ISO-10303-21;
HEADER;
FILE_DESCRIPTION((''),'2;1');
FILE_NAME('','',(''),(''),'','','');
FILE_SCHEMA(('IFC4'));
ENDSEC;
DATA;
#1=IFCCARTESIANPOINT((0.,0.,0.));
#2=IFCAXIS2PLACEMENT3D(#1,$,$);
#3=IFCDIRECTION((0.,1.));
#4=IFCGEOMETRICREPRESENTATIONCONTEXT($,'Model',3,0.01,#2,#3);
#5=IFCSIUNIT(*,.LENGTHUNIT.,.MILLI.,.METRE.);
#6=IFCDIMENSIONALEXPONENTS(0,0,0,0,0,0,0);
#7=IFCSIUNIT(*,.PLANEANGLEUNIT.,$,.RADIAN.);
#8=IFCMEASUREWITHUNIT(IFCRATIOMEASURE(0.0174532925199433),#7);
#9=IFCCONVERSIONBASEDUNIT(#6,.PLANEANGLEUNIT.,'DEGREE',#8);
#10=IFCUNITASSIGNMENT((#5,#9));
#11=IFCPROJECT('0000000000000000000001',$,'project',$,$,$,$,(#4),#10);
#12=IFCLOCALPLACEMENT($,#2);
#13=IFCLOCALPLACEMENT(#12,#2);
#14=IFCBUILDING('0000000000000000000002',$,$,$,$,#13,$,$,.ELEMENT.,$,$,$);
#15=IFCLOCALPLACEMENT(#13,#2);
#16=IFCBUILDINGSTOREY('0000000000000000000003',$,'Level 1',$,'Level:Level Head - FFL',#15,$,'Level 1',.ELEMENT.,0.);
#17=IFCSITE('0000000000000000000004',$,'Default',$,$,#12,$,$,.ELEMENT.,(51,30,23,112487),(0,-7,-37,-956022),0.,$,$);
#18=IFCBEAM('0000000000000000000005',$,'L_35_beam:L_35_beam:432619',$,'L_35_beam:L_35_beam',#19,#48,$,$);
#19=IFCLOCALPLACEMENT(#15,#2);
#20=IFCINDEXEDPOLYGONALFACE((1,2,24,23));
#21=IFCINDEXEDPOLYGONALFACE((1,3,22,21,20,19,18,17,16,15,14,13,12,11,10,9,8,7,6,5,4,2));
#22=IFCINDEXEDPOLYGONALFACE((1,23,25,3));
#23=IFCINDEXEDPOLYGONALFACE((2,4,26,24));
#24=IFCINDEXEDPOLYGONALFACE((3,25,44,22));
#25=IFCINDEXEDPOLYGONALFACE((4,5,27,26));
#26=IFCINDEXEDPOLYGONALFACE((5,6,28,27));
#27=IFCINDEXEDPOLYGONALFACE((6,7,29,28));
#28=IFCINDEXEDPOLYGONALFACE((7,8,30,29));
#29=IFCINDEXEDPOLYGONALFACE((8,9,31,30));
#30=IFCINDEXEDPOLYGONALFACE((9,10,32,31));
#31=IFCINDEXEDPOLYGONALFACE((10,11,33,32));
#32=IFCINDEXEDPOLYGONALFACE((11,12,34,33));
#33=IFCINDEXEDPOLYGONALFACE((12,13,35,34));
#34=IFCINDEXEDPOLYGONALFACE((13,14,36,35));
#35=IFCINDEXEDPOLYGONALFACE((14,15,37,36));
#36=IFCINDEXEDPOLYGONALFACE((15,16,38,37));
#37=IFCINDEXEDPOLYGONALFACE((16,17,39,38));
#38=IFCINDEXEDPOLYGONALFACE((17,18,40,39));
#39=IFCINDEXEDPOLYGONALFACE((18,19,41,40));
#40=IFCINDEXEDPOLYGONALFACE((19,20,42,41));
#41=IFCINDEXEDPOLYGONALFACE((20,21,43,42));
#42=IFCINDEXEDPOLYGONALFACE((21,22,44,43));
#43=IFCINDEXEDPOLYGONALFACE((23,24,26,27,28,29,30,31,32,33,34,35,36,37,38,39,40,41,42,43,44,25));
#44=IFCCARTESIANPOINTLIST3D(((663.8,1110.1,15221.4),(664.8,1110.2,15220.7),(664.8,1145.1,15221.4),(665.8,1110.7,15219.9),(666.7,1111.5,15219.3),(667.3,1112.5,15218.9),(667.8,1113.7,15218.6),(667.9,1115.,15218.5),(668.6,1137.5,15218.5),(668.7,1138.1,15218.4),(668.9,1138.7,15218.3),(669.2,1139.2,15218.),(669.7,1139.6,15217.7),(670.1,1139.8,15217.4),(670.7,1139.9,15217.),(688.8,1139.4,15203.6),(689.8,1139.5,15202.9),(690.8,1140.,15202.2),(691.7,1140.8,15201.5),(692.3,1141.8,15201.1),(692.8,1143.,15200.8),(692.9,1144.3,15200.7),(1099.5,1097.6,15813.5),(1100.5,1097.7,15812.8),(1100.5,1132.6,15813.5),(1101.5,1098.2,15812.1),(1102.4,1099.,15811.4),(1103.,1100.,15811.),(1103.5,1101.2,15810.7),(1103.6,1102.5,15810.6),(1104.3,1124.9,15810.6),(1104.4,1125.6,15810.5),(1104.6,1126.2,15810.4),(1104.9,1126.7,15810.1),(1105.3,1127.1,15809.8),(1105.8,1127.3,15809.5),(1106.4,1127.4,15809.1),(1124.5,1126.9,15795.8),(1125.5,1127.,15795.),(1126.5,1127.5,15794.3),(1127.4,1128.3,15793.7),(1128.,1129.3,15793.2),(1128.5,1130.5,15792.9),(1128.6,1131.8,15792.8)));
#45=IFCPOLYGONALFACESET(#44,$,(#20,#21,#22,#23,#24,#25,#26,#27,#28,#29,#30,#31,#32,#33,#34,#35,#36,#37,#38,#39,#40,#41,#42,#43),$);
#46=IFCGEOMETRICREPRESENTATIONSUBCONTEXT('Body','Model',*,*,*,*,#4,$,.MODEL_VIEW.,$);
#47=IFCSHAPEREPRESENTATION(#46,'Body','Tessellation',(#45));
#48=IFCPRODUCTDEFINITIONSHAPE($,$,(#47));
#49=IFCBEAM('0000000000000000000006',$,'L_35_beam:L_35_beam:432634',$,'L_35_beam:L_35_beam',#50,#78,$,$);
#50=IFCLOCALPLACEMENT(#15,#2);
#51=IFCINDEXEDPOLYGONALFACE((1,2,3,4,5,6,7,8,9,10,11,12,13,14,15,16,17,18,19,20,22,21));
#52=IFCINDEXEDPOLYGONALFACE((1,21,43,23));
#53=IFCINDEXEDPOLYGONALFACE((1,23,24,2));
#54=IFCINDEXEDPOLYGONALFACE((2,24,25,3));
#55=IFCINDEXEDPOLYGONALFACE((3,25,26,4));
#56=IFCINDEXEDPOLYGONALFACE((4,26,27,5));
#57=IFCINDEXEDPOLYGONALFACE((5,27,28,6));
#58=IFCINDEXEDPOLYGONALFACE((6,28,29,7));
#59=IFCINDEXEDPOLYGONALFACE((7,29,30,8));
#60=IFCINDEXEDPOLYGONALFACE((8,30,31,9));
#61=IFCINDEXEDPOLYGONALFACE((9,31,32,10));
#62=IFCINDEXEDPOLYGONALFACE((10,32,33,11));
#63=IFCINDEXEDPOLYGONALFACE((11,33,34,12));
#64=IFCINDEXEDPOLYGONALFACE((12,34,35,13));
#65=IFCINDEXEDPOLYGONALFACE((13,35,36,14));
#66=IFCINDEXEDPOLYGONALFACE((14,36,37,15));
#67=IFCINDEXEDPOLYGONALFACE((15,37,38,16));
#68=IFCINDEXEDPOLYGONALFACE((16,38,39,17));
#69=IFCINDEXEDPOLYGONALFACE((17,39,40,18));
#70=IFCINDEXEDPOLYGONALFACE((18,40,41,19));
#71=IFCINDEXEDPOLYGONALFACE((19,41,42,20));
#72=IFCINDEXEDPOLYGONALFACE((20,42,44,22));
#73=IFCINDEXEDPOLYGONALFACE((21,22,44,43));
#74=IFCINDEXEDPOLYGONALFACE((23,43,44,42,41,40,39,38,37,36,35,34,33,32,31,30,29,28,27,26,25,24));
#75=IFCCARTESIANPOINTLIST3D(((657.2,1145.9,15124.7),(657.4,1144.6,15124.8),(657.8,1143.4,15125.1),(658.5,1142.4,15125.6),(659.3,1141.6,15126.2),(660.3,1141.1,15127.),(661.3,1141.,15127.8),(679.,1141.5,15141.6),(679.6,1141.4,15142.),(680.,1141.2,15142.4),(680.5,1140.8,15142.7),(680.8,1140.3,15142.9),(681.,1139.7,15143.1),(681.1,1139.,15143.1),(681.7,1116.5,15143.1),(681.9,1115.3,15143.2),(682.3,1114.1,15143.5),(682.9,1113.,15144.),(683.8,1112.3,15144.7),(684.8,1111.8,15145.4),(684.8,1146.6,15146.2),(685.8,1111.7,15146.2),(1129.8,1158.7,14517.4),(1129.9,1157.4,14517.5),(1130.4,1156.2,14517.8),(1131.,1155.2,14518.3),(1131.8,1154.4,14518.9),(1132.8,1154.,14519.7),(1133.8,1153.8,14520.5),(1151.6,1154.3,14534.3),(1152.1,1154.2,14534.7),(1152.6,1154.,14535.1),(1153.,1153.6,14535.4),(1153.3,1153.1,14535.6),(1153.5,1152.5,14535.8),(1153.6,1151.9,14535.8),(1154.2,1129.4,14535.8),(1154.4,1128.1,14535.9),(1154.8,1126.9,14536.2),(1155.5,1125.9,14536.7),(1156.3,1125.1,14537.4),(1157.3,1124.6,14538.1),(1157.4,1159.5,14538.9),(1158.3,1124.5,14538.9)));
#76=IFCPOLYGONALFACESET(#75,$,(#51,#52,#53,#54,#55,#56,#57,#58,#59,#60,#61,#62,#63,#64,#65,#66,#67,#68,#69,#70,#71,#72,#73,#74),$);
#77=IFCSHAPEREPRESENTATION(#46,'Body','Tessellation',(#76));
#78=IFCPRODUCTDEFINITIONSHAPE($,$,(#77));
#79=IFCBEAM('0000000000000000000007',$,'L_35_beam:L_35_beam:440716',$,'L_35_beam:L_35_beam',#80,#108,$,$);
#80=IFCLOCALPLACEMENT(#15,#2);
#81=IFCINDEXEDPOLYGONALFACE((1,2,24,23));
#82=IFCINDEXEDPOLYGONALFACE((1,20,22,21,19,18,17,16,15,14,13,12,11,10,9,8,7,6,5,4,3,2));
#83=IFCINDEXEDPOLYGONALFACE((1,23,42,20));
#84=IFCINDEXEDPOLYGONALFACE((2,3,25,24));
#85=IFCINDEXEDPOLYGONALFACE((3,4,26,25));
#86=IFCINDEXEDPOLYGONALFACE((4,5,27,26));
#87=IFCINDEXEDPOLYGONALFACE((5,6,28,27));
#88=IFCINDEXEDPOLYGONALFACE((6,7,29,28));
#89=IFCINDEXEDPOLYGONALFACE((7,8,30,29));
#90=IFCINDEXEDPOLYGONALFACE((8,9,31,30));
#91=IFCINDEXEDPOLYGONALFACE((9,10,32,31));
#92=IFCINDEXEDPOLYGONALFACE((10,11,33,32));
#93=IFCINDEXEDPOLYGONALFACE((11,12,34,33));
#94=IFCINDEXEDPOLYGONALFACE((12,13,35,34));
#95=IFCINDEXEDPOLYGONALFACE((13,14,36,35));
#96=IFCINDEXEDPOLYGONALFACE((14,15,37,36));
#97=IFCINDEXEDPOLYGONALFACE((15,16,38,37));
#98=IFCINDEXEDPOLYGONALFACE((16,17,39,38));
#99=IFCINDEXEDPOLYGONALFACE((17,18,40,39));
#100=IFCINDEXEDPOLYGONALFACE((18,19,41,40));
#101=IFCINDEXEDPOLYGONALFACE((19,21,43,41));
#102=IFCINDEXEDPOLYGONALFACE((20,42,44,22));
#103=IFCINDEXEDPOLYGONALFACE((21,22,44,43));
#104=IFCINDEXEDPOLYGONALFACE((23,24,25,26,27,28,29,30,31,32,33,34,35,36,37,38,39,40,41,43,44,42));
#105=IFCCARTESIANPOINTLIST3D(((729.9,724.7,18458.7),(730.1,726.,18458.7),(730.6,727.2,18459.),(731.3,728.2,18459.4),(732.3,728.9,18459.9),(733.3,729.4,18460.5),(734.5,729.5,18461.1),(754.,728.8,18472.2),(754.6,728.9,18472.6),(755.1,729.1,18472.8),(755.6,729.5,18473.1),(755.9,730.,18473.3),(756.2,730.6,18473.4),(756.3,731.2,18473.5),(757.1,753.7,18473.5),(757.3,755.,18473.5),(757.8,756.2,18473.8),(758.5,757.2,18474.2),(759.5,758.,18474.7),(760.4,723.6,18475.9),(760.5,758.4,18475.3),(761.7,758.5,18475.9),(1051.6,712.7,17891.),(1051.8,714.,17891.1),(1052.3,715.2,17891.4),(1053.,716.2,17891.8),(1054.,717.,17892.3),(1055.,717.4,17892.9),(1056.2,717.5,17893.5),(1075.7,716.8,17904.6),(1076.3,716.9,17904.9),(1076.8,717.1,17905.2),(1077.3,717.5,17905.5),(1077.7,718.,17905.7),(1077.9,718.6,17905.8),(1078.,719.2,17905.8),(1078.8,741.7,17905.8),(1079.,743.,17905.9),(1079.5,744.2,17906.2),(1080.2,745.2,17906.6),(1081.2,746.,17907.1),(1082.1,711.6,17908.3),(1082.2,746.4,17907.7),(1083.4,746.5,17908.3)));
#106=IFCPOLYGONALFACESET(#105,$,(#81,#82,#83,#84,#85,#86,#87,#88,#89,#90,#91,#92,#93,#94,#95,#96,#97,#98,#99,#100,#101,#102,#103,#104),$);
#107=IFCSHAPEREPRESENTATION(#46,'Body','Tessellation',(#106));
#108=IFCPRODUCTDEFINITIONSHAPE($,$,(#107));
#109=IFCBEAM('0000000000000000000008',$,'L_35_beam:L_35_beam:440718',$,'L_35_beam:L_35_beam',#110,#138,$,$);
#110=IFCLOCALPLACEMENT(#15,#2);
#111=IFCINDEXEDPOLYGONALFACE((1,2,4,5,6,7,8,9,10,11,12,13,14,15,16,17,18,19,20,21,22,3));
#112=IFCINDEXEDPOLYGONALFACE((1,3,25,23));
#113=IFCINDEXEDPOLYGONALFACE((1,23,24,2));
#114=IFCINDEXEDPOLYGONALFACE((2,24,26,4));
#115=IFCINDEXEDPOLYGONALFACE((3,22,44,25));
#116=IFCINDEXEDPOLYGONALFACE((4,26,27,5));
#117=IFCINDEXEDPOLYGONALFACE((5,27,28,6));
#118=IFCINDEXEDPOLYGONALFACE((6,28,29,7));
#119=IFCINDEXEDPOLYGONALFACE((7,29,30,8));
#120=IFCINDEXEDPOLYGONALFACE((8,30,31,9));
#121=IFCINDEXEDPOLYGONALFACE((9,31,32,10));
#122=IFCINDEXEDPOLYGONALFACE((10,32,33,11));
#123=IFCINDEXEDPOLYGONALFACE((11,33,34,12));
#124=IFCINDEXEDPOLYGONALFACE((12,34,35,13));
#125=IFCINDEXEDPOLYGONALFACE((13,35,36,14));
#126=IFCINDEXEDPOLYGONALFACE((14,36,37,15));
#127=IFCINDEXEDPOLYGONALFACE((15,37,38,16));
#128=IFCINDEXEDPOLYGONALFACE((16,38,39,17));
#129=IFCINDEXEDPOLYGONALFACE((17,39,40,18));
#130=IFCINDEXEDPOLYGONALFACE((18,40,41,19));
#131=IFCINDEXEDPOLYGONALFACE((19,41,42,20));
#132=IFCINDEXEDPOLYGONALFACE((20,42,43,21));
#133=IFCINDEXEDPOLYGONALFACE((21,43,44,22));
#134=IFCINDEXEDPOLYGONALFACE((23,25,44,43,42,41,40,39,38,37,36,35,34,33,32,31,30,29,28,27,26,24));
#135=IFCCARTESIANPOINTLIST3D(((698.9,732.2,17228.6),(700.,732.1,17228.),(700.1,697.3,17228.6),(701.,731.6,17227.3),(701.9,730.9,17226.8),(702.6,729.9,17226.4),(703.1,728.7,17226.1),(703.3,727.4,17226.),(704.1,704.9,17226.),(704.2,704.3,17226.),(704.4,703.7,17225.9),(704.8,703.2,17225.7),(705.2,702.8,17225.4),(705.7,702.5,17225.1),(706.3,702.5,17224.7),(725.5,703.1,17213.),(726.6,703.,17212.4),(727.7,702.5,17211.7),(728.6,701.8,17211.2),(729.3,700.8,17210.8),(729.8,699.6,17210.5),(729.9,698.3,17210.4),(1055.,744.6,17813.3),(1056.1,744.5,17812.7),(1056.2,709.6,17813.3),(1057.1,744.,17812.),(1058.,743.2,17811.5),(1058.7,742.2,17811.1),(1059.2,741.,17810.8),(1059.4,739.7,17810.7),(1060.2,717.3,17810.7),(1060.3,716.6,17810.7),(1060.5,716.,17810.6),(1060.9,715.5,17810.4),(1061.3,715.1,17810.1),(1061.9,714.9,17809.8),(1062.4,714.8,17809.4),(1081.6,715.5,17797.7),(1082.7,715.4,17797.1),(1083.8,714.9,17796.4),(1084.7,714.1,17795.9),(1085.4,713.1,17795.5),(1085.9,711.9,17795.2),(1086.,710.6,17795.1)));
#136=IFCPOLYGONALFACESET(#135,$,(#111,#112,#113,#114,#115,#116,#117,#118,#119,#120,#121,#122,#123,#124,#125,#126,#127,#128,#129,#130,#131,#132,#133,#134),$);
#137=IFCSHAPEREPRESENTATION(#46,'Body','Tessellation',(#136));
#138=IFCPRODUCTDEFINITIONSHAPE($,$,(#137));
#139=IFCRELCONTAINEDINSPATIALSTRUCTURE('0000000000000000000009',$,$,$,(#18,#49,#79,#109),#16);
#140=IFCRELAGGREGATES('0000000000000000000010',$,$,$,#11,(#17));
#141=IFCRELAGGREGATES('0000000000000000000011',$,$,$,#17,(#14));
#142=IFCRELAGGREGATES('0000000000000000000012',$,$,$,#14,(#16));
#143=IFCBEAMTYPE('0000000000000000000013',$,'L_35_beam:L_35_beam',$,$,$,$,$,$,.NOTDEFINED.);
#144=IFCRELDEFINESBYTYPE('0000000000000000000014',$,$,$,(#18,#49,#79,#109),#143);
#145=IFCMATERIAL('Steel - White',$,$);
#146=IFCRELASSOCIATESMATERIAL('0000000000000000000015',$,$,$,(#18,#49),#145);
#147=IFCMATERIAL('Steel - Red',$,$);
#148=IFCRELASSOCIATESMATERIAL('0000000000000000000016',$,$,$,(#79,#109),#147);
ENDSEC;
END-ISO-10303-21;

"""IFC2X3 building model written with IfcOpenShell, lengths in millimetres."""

from ifc_helpers import new_model, entity, si_unit, converted_unit, direction, frame, frame_2d, origin, place, context, subcontext, project, spatial, polyline, circle_curve, parameter, trimmed, segment, composite_curve, outline, extrude, material, type_object, element, save


model = new_model("IFC2X3")

# Units and contexts
model_context = context("Model", 3, precision=0.01, world=origin(), true_north=direction((0.0, 1.0)))
body_context = subcontext(model_context, "Body", "Model", "MODEL_VIEW")
ifc_project = project(units=[si_unit("LENGTHUNIT", "METRE", prefix="MILLI"), converted_unit("PLANEANGLEUNIT", "DEGREE", entity("IfcRatioMeasure", 0.0174532925199433), si_unit("PLANEANGLEUNIT", "RADIAN"), dimensions=[0, 0, 0, 0, 0, 0, 0])], contexts=[model_context])

# Site, building, storey
site_placement = place(None, origin())
site = spatial("IfcSite", under=ifc_project, at=site_placement, Name="Default", CompositionType="ELEMENT", RefLatitude=(51, 30, 23, 112487), RefLongitude=(0, -7, -37, -956022), RefElevation=0.0)
building_placement = place(site_placement, origin())
building = spatial("IfcBuilding", under=site, at=building_placement, CompositionType="ELEMENT")
storey_placement = place(building_placement, origin())
storey = spatial("IfcBuildingStorey", under=building, at=storey_placement, Name="Level 1", ObjectType="Level:Level Head - FFL", LongName="Level 1", CompositionType="ELEMENT", Elevation=0.0)

# Beams
ifc_material_1 = material(Name="Steel - Red")
ifc_material_2 = material(Name="Steel - White")
beam_type_1 = type_object("IfcBeamType", Name="L_35_beam:L_35_beam", PredefinedType="NOTDEFINED")
beam_1_placement = place(storey_placement, frame((646.5, 1153.6, 15166.7), z_axis=(0.805503, 0.012518, -0.592459), x_axis=(0.592591, -0.017016, 0.805324)))
element("IfcBeam", 1, at=beam_1_placement, inside=storey, type_object=beam_type_1, material=ifc_material_2, Name="L_35_beam:L_35_beam:432619", ObjectType="L_35_beam:L_35_beam", context=body_context, shape_type="SweptSolid", body=[
    extrude(outline(composite_curve([segment(polyline([(-4.3, 6.8), (18.2, 6.8)]), True, "CONTINUOUS"), segment(trimmed(circle_curve(frame_2d((18.2, 11.8), x_axis=(0.0, -1.0)), 5.0), [parameter(0.0)], [parameter(90.0)], True, "PARAMETER"), True, "CONTINUOUS"), segment(polyline([(23.2, 11.8), (-11.8, 11.8)]), True, "CONTINUOUS"), segment(polyline([(-11.8, 11.8), (-11.8, -23.2)]), True, "CONTINUOUS"), segment(trimmed(circle_curve(frame_2d((-11.8, -18.2), x_axis=(0.0, -1.0)), 5.0), [parameter(0.0)], [parameter(90.0)], True, "PARAMETER"), True, "CONTINUOUS"), segment(polyline([(-6.8, -18.2), (-6.8, 4.3)]), True, "CONTINUOUS"), segment(trimmed(circle_curve(frame_2d((-4.3, 4.3), x_axis=(-1.0, 0.0)), 2.5), [parameter(270.0)], [parameter(0.0)], True, "PARAMETER"), False, "CONTINUOUS")], self_intersect=False)), frame((55.0, 19.6, -6.4), z_axis=(1.0, 0.0, 0.0), x_axis=(0.0, 0.035633, 0.999365)), (0.0, 0.0, 1.0), 735.2),
])
beam_2_placement = place(storey_placement, frame((646.5, 1153.6, 15166.7), z_axis=(0.789291, -0.012971, 0.613882), x_axis=(0.614019, 0.016674, -0.789115)))
element("IfcBeam", 2, at=beam_2_placement, inside=storey, type_object=beam_type_1, material=ifc_material_2, Name="L_35_beam:L_35_beam:432634", ObjectType="L_35_beam:L_35_beam", context=body_context, shape_type="SweptSolid", body=[
    extrude(outline(composite_curve([segment(polyline([(-23.2, -11.8), (11.8, -11.8)]), True, "CONTINUOUS"), segment(polyline([(11.8, -11.8), (11.8, 23.2)]), True, "CONTINUOUS"), segment(trimmed(circle_curve(frame_2d((11.8, 18.2), x_axis=(0.0, 1.0)), 5.0), [parameter(0.0)], [parameter(90.0)], True, "PARAMETER"), True, "CONTINUOUS"), segment(polyline([(6.8, 18.2), (6.8, -4.3)]), True, "CONTINUOUS"), segment(trimmed(circle_curve(frame_2d((4.3, -4.3), x_axis=(1.0, 0.0)), 2.5), [parameter(270.0)], [parameter(0.0)], True, "PARAMETER"), False, "CONTINUOUS"), segment(polyline([(4.3, -6.8), (-18.2, -6.8)]), True, "CONTINUOUS"), segment(trimmed(circle_curve(frame_2d((-18.2, -11.8), x_axis=(0.0, 1.0)), 5.0), [parameter(0.0)], [parameter(90.0)], True, "PARAMETER"), True, "CONTINUOUS")], self_intersect=False)), frame((39.6, -19.6, 6.4), z_axis=(1.0, 0.0, 0.0), x_axis=(0.0, 0.034391, 0.999408)), (0.0, 0.0, 1.0), 769.6),
])
beam_3_placement = place(storey_placement, frame((1096.9, 703.0, 17846.1), z_axis=(0.870031, 0.010414, 0.492887), x_axis=(-0.492997, 0.018379, 0.869837)))
element("IfcBeam", 3, at=beam_3_placement, inside=storey, type_object=beam_type_1, material=ifc_material_1, Name="L_35_beam:L_35_beam:440716", ObjectType="L_35_beam:L_35_beam", context=body_context, shape_type="SweptSolid", body=[
    extrude(outline(composite_curve([segment(polyline([(-23.2, -11.8), (11.8, -11.8)]), True, "CONTINUOUS"), segment(polyline([(11.8, -11.8), (11.8, 23.2)]), True, "CONTINUOUS"), segment(trimmed(circle_curve(frame_2d((11.8, 18.2), x_axis=(0.0, 1.0)), 5.0), [parameter(0.0)], [parameter(90.0)], True, "PARAMETER"), True, "CONTINUOUS"), segment(polyline([(6.8, 18.2), (6.8, -4.3)]), True, "CONTINUOUS"), segment(trimmed(circle_curve(frame_2d((4.3, -4.3), x_axis=(1.0, 0.0)), 2.5), [parameter(270.0)], [parameter(0.0)], True, "PARAMETER"), False, "CONTINUOUS"), segment(polyline([(4.3, -6.8), (-18.2, -6.8)]), True, "CONTINUOUS"), segment(trimmed(circle_curve(frame_2d((-18.2, -11.8), x_axis=(0.0, 1.0)), 5.0), [parameter(0.0)], [parameter(90.0)], True, "PARAMETER"), True, "CONTINUOUS")], self_intersect=False)), frame((61.6, -19.5, 6.6), z_axis=(1.0, 0.0, 0.0), x_axis=(0.0, 0.04282, 0.999083)), (0.0, 0.0, 1.0), 652.6),
])
beam_4_placement = place(storey_placement, frame((1096.9, 703.0, 17846.1), z_axis=(0.854121, -0.010986, -0.519959), x_axis=(-0.520075, -0.018043, -0.85393)))
element("IfcBeam", 4, at=beam_4_placement, inside=storey, type_object=beam_type_1, material=ifc_material_1, Name="L_35_beam:L_35_beam:440718", ObjectType="L_35_beam:L_35_beam", context=body_context, shape_type="SweptSolid", body=[
    extrude(outline(composite_curve([segment(polyline([(-4.3, 6.8), (18.2, 6.8)]), True, "CONTINUOUS"), segment(trimmed(circle_curve(frame_2d((18.2, 11.8), x_axis=(0.0, -1.0)), 5.0), [parameter(0.0)], [parameter(90.0)], True, "PARAMETER"), True, "CONTINUOUS"), segment(polyline([(23.2, 11.8), (-11.8, 11.8)]), True, "CONTINUOUS"), segment(polyline([(-11.8, 11.8), (-11.8, -23.2)]), True, "CONTINUOUS"), segment(trimmed(circle_curve(frame_2d((-11.8, -18.2), x_axis=(0.0, -1.0)), 5.0), [parameter(0.0)], [parameter(90.0)], True, "PARAMETER"), True, "CONTINUOUS"), segment(polyline([(-6.8, -18.2), (-6.8, 4.3)]), True, "CONTINUOUS"), segment(trimmed(circle_curve(frame_2d((-4.3, 4.3), x_axis=(-1.0, 0.0)), 2.5), [parameter(270.0)], [parameter(0.0)], True, "PARAMETER"), False, "CONTINUOUS")], self_intersect=False)), frame((49.1, 19.5, -6.5), z_axis=(1.0, 0.0, 0.0), x_axis=(0.0, 0.040594, 0.999176)), (0.0, 0.0, 1.0), 684.7),
])

save(model, "model.ifc")
